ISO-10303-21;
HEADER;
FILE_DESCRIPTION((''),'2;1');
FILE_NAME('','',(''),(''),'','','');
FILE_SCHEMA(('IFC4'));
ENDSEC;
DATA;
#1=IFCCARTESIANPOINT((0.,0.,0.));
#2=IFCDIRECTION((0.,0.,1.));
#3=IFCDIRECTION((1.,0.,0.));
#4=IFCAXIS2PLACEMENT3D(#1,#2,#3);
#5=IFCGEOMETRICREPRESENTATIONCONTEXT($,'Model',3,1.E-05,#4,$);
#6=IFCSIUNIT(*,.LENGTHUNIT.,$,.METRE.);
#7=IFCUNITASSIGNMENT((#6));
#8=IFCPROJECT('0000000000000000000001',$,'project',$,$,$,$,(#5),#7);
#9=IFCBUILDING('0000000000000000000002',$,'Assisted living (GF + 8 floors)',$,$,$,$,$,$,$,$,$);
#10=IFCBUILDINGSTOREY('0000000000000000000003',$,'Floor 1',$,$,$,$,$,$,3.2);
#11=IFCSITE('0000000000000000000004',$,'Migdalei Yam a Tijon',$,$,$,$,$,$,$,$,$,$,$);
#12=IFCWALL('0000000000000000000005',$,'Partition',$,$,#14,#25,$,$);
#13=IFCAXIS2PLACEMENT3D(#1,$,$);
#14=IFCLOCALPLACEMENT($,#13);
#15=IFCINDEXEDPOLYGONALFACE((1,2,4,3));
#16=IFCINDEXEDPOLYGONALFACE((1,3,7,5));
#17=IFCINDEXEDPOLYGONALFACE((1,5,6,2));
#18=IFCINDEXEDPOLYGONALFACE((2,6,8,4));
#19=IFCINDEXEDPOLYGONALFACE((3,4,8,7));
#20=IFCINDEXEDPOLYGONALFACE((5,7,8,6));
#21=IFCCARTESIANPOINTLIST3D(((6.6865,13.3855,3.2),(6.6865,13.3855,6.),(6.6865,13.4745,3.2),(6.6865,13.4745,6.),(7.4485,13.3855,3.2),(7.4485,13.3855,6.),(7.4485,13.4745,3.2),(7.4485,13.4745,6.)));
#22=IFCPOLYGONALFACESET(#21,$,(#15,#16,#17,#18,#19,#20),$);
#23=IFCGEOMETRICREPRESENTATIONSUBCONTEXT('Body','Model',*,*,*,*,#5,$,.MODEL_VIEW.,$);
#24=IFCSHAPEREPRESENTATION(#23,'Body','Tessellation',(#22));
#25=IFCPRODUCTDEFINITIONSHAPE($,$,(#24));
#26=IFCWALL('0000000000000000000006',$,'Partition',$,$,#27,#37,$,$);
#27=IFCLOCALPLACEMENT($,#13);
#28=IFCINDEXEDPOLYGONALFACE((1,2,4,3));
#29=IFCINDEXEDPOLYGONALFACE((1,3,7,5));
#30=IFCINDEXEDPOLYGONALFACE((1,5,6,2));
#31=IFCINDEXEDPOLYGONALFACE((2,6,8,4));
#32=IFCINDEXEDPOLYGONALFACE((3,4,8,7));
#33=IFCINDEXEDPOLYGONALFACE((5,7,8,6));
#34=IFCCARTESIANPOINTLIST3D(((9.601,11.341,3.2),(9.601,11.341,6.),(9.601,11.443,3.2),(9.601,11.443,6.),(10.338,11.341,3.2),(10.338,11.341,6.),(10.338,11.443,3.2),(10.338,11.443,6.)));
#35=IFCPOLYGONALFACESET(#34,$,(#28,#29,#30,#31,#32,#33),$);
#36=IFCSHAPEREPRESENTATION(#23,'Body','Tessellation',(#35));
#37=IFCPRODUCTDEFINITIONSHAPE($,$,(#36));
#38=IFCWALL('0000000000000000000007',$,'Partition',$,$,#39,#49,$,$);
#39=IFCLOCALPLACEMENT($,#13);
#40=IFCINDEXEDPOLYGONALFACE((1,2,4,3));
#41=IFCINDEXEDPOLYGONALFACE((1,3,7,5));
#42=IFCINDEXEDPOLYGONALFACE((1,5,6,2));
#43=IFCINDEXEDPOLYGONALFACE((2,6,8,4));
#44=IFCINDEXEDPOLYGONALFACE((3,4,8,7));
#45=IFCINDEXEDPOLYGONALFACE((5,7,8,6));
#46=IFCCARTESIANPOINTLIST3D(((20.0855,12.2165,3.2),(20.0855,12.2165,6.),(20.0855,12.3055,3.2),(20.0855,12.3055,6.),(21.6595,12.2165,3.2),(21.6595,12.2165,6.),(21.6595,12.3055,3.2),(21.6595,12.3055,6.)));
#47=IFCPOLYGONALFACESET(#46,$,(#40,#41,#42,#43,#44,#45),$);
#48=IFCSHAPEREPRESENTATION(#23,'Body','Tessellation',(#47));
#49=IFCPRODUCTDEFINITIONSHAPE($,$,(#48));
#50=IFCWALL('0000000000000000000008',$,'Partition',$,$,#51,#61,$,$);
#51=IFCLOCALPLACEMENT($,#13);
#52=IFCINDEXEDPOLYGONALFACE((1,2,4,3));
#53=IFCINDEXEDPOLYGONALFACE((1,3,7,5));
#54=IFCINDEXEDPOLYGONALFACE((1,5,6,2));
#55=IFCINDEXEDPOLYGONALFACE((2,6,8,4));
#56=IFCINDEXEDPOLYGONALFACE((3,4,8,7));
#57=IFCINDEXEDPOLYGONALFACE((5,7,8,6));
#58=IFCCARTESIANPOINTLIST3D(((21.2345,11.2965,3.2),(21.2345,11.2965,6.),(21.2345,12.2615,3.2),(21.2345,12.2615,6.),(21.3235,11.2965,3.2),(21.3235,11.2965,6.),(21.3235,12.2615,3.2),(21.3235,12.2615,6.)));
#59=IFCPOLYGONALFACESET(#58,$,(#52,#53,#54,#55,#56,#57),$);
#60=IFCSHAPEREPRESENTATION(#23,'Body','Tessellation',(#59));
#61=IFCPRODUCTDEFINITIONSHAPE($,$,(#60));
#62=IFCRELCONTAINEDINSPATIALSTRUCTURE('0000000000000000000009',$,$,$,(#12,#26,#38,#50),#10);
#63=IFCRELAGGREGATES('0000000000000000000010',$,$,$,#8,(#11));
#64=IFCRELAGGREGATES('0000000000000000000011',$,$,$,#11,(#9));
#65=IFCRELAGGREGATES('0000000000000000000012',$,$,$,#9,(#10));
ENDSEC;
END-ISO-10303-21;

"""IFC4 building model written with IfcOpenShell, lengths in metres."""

from ifc_helpers import new_model, si_unit, frame, origin_with_axes, context, subcontext, project, spatial, line, indexed_curve, outline, extrude, element, save


model = new_model("IFC4")

# Units and contexts
model_context = context("Model", 3, precision=1e-05, world=origin_with_axes())
body_context = subcontext(model_context, "Body", "Model", "MODEL_VIEW")
ifc_project = project(units=[si_unit("LENGTHUNIT", "METRE")], contexts=[model_context])

# Site, building, storey
site = spatial("IfcSite", under=ifc_project, Name="Migdalei Yam a Tijon")
building = spatial("IfcBuilding", under=site, Name="Assisted living (GF + 8 floors)")
storey = spatial("IfcBuildingStorey", under=building, Name="Floor 1", Elevation=3.2)

# Walls
element("IfcWall", 1, inside=storey, Name="Partition", context=body_context, shape_type="SweptSolid", body=[
    extrude(outline(indexed_curve([(0.0, 0.0), (0.762, 0.0), (0.762, 0.089), (0.0, 0.089)], segments=[line(1, 2, 3, 4, 1)])), frame((6.6865, 13.3855, 3.2), z_axis=(0.0, 0.0, 1.0), x_axis=(1.0, 0.0, 0.0)), (0.0, 0.0, 1.0), 2.8),
])
element("IfcWall", 2, inside=storey, Name="Partition", context=body_context, shape_type="SweptSolid", body=[
    extrude(outline(indexed_curve([(0.0, 0.0), (0.737, 0.0), (0.737, 0.102), (0.0, 0.102)], segments=[line(1, 2, 3, 4, 1)])), frame((9.601, 11.341, 3.2), z_axis=(0.0, 0.0, 1.0), x_axis=(1.0, 0.0, 0.0)), (0.0, 0.0, 1.0), 2.8),
])
element("IfcWall", 3, inside=storey, Name="Partition", context=body_context, shape_type="SweptSolid", body=[
    extrude(outline(indexed_curve([(0.0, 0.0), (1.574, 0.0), (1.574, 0.089), (0.0, 0.089)], segments=[line(1, 2, 3, 4, 1)])), frame((20.0855, 12.2165, 3.2), z_axis=(0.0, 0.0, 1.0), x_axis=(1.0, 0.0, 0.0)), (0.0, 0.0, 1.0), 2.8),
])
element("IfcWall", 4, inside=storey, Name="Partition", context=body_context, shape_type="SweptSolid", body=[
    extrude(outline(indexed_curve([(0.0, 0.0), (0.089, 0.0), (0.089, 0.965), (0.0, 0.965)], segments=[line(1, 2, 3, 4, 1)])), frame((21.2345, 11.2965, 3.2), z_axis=(0.0, 0.0, 1.0), x_axis=(1.0, 0.0, 0.0)), (0.0, 0.0, 1.0), 2.8),
])

save(model, "model.ifc")
